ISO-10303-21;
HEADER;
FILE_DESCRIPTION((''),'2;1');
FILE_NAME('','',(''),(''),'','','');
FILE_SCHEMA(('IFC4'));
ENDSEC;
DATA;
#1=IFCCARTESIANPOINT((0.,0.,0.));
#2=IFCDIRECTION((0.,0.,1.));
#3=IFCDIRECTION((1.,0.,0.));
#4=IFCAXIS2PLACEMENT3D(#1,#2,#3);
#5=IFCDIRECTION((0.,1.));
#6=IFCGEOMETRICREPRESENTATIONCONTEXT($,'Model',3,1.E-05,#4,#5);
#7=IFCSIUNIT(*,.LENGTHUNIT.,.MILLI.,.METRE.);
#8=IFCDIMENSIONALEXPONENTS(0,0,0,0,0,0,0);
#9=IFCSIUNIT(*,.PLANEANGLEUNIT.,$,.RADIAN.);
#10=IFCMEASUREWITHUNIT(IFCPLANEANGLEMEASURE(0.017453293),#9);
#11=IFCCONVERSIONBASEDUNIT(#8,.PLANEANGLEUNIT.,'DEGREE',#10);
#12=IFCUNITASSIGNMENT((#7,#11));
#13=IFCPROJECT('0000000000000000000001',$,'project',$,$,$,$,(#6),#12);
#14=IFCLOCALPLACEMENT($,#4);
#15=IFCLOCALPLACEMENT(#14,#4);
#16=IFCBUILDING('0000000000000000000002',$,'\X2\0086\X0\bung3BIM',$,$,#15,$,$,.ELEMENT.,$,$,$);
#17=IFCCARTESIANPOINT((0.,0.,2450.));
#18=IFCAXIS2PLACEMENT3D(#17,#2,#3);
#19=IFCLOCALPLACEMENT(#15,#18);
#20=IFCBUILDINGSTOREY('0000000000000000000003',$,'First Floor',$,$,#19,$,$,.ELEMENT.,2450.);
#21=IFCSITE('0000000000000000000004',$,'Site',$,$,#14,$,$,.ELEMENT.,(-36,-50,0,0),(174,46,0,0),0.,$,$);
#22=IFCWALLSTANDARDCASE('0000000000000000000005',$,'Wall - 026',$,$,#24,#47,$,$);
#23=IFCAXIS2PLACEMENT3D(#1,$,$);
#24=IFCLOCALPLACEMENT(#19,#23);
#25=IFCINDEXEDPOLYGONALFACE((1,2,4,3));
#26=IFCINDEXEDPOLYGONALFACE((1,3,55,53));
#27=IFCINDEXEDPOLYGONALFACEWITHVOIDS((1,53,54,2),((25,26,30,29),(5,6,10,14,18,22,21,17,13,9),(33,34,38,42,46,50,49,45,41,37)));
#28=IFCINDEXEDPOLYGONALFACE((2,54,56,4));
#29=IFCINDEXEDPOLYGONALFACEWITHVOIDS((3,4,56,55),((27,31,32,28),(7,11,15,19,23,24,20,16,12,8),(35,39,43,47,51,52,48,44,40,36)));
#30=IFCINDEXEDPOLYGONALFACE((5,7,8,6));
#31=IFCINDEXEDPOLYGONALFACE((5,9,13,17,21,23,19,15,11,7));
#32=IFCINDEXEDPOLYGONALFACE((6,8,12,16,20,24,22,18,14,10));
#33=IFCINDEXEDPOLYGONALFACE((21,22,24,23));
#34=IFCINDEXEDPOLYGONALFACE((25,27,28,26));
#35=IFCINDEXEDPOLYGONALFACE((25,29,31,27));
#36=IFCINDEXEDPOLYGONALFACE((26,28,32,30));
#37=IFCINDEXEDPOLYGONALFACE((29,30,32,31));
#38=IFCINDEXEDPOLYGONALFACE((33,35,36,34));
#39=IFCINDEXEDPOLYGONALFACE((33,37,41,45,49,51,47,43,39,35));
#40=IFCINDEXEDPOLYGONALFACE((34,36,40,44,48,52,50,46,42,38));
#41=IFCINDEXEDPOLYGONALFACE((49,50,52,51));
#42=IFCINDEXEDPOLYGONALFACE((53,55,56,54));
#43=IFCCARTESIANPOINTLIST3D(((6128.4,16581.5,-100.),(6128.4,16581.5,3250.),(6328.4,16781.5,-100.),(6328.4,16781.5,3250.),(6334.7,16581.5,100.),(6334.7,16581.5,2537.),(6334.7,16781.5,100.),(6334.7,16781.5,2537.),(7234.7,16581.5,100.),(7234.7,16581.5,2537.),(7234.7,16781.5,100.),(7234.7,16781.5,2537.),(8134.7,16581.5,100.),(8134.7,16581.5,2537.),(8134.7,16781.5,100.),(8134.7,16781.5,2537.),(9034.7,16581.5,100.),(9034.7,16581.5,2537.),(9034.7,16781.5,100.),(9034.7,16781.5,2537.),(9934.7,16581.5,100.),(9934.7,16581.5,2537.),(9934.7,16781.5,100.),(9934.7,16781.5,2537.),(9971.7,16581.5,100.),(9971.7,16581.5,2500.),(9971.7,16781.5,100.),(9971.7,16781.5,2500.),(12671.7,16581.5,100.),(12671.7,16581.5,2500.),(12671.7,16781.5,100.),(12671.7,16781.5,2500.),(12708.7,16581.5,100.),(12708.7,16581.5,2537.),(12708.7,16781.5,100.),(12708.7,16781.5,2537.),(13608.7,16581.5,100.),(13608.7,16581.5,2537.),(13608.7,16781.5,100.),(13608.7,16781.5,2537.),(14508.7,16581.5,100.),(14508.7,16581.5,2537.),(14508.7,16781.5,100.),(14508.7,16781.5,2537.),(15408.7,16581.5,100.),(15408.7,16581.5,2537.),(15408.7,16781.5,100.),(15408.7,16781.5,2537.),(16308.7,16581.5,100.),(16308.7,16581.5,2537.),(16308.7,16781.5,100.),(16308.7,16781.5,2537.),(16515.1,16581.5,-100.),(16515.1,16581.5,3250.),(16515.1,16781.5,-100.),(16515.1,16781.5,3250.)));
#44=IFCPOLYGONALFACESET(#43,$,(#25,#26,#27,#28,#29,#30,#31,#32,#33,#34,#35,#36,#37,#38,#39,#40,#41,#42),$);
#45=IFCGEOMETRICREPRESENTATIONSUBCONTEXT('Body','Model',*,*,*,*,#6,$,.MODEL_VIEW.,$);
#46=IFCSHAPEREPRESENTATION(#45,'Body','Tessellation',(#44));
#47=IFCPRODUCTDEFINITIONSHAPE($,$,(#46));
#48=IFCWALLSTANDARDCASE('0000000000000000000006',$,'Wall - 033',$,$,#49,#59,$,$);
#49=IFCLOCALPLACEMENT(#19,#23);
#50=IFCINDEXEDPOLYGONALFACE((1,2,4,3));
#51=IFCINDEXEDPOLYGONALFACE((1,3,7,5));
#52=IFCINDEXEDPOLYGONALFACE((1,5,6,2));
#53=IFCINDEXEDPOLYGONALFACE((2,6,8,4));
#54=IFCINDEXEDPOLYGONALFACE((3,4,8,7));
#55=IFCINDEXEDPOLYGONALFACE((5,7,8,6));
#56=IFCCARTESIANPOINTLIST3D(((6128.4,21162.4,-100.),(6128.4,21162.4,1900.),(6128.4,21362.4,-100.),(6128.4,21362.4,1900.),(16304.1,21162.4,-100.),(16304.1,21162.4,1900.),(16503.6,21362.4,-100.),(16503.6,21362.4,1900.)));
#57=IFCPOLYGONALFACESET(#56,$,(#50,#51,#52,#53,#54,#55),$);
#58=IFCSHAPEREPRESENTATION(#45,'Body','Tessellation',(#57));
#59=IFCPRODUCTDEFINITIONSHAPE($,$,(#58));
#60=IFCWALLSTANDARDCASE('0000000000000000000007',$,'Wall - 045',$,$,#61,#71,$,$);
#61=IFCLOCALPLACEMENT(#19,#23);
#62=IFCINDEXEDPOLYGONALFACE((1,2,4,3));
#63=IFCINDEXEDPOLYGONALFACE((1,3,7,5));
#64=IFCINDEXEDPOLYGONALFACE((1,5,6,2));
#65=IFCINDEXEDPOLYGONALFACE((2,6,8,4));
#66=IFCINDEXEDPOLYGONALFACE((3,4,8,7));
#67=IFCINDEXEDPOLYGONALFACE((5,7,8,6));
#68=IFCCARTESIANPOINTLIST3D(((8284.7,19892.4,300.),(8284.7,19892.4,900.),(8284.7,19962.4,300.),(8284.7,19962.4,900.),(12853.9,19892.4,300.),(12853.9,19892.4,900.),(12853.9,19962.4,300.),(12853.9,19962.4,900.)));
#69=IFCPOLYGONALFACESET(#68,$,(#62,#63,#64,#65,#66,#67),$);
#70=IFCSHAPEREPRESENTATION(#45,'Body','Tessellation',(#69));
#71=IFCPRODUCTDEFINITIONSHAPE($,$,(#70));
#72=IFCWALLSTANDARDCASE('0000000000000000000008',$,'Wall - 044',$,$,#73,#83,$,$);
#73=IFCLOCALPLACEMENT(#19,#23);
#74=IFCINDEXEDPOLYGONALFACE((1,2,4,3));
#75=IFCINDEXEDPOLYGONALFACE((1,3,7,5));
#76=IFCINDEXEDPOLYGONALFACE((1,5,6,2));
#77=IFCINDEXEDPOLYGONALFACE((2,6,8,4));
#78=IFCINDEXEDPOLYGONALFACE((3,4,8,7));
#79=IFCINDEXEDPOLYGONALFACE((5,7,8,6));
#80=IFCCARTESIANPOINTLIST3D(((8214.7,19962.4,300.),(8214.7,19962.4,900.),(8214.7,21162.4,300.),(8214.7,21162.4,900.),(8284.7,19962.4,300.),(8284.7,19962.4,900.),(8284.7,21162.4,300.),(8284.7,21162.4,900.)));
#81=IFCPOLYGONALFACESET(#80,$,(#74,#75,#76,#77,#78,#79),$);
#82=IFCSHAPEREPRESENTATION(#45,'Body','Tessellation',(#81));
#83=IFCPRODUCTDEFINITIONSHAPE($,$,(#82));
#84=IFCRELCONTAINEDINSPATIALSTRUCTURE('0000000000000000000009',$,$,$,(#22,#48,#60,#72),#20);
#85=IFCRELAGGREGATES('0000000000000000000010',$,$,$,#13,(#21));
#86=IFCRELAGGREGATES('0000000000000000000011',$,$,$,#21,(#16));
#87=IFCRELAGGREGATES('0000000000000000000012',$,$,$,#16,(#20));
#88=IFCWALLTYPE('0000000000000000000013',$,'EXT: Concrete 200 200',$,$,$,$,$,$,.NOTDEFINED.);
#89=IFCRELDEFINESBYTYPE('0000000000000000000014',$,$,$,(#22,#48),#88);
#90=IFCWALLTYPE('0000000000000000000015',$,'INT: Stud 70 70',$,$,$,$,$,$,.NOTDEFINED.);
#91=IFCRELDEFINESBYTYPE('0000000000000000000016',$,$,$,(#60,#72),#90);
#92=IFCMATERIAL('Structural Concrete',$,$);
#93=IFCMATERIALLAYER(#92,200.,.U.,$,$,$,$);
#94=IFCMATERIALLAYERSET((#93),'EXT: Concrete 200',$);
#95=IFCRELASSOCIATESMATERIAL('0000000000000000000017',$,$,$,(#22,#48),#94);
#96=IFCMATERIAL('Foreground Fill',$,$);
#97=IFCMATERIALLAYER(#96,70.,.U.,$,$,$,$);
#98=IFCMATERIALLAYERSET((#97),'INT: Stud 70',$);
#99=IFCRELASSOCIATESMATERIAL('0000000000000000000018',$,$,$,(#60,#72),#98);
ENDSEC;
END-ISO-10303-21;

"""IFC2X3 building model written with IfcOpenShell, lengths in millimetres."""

from ifc_helpers import new_model, entity, si_unit, converted_unit, direction, frame, origin_with_axes, origin_2d_with_axis, place, context, subcontext, project, spatial, polyline, rectangle, outline, extrude, material, layer, layer_set, layer_usage, type_object, element, save


model = new_model("IFC2X3")

# Units and contexts
model_context = context("Model", 3, precision=1e-05, world=origin_with_axes(), true_north=direction((0.0, 1.0)))
body_context = subcontext(model_context, "Body", "Model", "MODEL_VIEW")
ifc_project = project(units=[si_unit("LENGTHUNIT", "METRE", prefix="MILLI"), converted_unit("PLANEANGLEUNIT", "DEGREE", entity("IfcPlaneAngleMeasure", 0.017453293), si_unit("PLANEANGLEUNIT", "RADIAN"), dimensions=[0, 0, 0, 0, 0, 0, 0])], contexts=[model_context])

# Site, building, storey
site_placement = place(None, origin_with_axes())
site = spatial("IfcSite", under=ifc_project, at=site_placement, Name="Site", CompositionType="ELEMENT", RefLatitude=(-36, -50, 0, 0), RefLongitude=(174, 46, 0, 0), RefElevation=0.0)
building_placement = place(site_placement, origin_with_axes())
building = spatial("IfcBuilding", under=site, at=building_placement, Name="\u0086bung3BIM", CompositionType="ELEMENT")
storey_placement = place(building_placement, frame((0.0, 0.0, 2450.0), z_axis=(0.0, 0.0, 1.0), x_axis=(1.0, 0.0, 0.0)))
storey = spatial("IfcBuildingStorey", under=building, at=storey_placement, Name="First Floor", CompositionType="ELEMENT", Elevation=2450.0)

# Shared definitions
ifc_material_1 = material(Name="Foreground Fill")

# Wall, openings
ifc_material_2 = material(Name="Structural Concrete")
ifc_layer_1 = layer(ifc_material_2, 200.0, ventilated="UNKNOWN")
ifc_layer_set_1 = layer_set([ifc_layer_1], Name="EXT: Concrete 200")
ifc_layer_usage_1 = layer_usage(ifc_layer_set_1, "AXIS2", "POSITIVE", 0.0)
wall_type_1 = type_object("IfcWallType", Name="EXT: Concrete 200 200", PredefinedType="NOTDEFINED")
wall_1_placement = place(storey_placement, frame((16515.1, 16781.5, -100.0), z_axis=(0.0, 0.0, 1.0), x_axis=(-1.0, 0.0, 0.0)))
wall_1 = element("IfcWallStandardCase", 1, at=wall_1_placement, inside=storey, type_object=wall_type_1, material=ifc_layer_usage_1, Name="Wall - 026", context=body_context, shape_type="SweptSolid", body=[
    extrude(outline(polyline([(0.0, 0.0), (10186.8, 0.0), (10386.8, 200.0), (0.0, 200.0), (0.0, 0.0)])), origin_with_axes(), (0.0, 0.0, 1.0), 3350.0),
])
opening_1_placement = place(wall_1_placement, frame((7930.4, 0.0, 200.0), z_axis=(0.0, 0.0, 1.0), x_axis=(1.0, 0.0, 0.0)))
element("IfcOpeningElement", 2, at=opening_1_placement, cuts=wall_1, context=body_context, shape_type="SweptSolid", body=[
    extrude(rectangle(XDim=900.0, YDim=2437.0, at=origin_2d_with_axis()), frame((0.0, -200.0, 1218.5), z_axis=(0.0, 1.0, 0.0), x_axis=(1.0, 0.0, 0.0)), (0.0, 0.0, 1.0), 600.0),
])
opening_2_placement = place(wall_1_placement, frame((8830.4, 0.0, 200.0), z_axis=(0.0, 0.0, 1.0), x_axis=(1.0, 0.0, 0.0)))
element("IfcOpeningElement", 3, at=opening_2_placement, cuts=wall_1, context=body_context, shape_type="SweptSolid", body=[
    extrude(rectangle(XDim=900.0, YDim=2437.0, at=origin_2d_with_axis()), frame((0.0, -200.0, 1218.5), z_axis=(0.0, 1.0, 0.0), x_axis=(1.0, 0.0, 0.0)), (0.0, 0.0, 1.0), 600.0),
])
opening_3_placement = place(wall_1_placement, frame((3356.4, 0.0, 200.0), z_axis=(0.0, 0.0, 1.0), x_axis=(1.0, 0.0, 0.0)))
element("IfcOpeningElement", 4, at=opening_3_placement, cuts=wall_1, context=body_context, shape_type="SweptSolid", body=[
    extrude(rectangle(XDim=900.0, YDim=2437.0, at=origin_2d_with_axis()), frame((0.0, -200.0, 1218.5), z_axis=(0.0, 1.0, 0.0), x_axis=(1.0, 0.0, 0.0)), (0.0, 0.0, 1.0), 600.0),
])
opening_4_placement = place(wall_1_placement, frame((5193.4, 0.0, 200.0), z_axis=(0.0, 0.0, 1.0), x_axis=(1.0, 0.0, 0.0)))
element("IfcOpeningElement", 5, at=opening_4_placement, cuts=wall_1, context=body_context, shape_type="SweptSolid", body=[
    extrude(rectangle(XDim=2700.0, YDim=2400.0, at=origin_2d_with_axis()), frame((0.0, -200.0, 1200.0), z_axis=(0.0, 1.0, 0.0), x_axis=(1.0, 0.0, 0.0)), (0.0, 0.0, 1.0), 600.0),
    extrude(rectangle(XDim=2774.0, YDim=2437.0, at=origin_2d_with_axis()), frame((0.0, -200.0, 1218.5), z_axis=(0.0, 1.0, 0.0), x_axis=(1.0, 0.0, 0.0)), (0.0, 0.0, 1.0), 200.0),
    extrude(rectangle(XDim=2774.0, YDim=2437.0, at=origin_2d_with_axis()), frame((0.0, 400.0, 1218.5), z_axis=(0.0, -1.0, 0.0), x_axis=(1.0, 0.0, 0.0)), (0.0, 0.0, 1.0), 200.0),
])
opening_5_placement = place(wall_1_placement, frame((2456.4, 0.0, 200.0), z_axis=(0.0, 0.0, 1.0), x_axis=(1.0, 0.0, 0.0)))
element("IfcOpeningElement", 6, at=opening_5_placement, cuts=wall_1, context=body_context, shape_type="SweptSolid", body=[
    extrude(rectangle(XDim=900.0, YDim=2437.0, at=origin_2d_with_axis()), frame((0.0, -200.0, 1218.5), z_axis=(0.0, 1.0, 0.0), x_axis=(1.0, 0.0, 0.0)), (0.0, 0.0, 1.0), 600.0),
])
opening_6_placement = place(wall_1_placement, frame((7030.4, 0.0, 200.0), z_axis=(0.0, 0.0, 1.0), x_axis=(1.0, 0.0, 0.0)))
element("IfcOpeningElement", 7, at=opening_6_placement, cuts=wall_1, context=body_context, shape_type="SweptSolid", body=[
    extrude(rectangle(XDim=900.0, YDim=2437.0, at=origin_2d_with_axis()), frame((0.0, -200.0, 1218.5), z_axis=(0.0, 1.0, 0.0), x_axis=(1.0, 0.0, 0.0)), (0.0, 0.0, 1.0), 600.0),
])
opening_7_placement = place(wall_1_placement, frame((9730.4, 0.0, 200.0), z_axis=(0.0, 0.0, 1.0), x_axis=(1.0, 0.0, 0.0)))
element("IfcOpeningElement", 8, at=opening_7_placement, cuts=wall_1, context=body_context, shape_type="SweptSolid", body=[
    extrude(rectangle(XDim=900.0, YDim=2437.0, at=origin_2d_with_axis()), frame((0.0, -200.0, 1218.5), z_axis=(0.0, 1.0, 0.0), x_axis=(1.0, 0.0, 0.0)), (0.0, 0.0, 1.0), 600.0),
])
opening_8_placement = place(wall_1_placement, frame((1556.4, 0.0, 200.0), z_axis=(0.0, 0.0, 1.0), x_axis=(1.0, 0.0, 0.0)))
element("IfcOpeningElement", 9, at=opening_8_placement, cuts=wall_1, context=body_context, shape_type="SweptSolid", body=[
    extrude(rectangle(XDim=900.0, YDim=2437.0, at=origin_2d_with_axis()), frame((0.0, -200.0, 1218.5), z_axis=(0.0, 1.0, 0.0), x_axis=(1.0, 0.0, 0.0)), (0.0, 0.0, 1.0), 600.0),
])
opening_9_placement = place(wall_1_placement, frame((656.4, 0.0, 200.0), z_axis=(0.0, 0.0, 1.0), x_axis=(1.0, 0.0, 0.0)))
element("IfcOpeningElement", 10, at=opening_9_placement, cuts=wall_1, context=body_context, shape_type="SweptSolid", body=[
    extrude(rectangle(XDim=900.0, YDim=2437.0, at=origin_2d_with_axis()), frame((0.0, -200.0, 1218.5), z_axis=(0.0, 1.0, 0.0), x_axis=(1.0, 0.0, 0.0)), (0.0, 0.0, 1.0), 600.0),
])

# Walls
ifc_layer_usage_2 = layer_usage(ifc_layer_set_1, "AXIS2", "POSITIVE", 0.0)
wall_2_placement = place(storey_placement, frame((6128.4, 21162.4, -100.0), z_axis=(0.0, 0.0, 1.0), x_axis=(1.0, 0.0, 0.0)))
element("IfcWallStandardCase", 11, at=wall_2_placement, inside=storey, type_object=wall_type_1, material=ifc_layer_usage_2, Name="Wall - 033", context=body_context, shape_type="SweptSolid", body=[
    extrude(outline(polyline([(0.0, 0.0), (10175.8, 0.0), (10375.3, 200.0), (0.0, 200.0), (0.0, 0.0)])), origin_with_axes(), (0.0, 0.0, 1.0), 2000.0),
])
ifc_layer_2 = layer(ifc_material_1, 70.0, ventilated="UNKNOWN")
ifc_layer_set_2 = layer_set([ifc_layer_2], Name="INT: Stud 70")
ifc_layer_usage_3 = layer_usage(ifc_layer_set_2, "AXIS2", "POSITIVE", 0.0)
wall_type_2 = type_object("IfcWallType", Name="INT: Stud 70 70", PredefinedType="NOTDEFINED")
wall_3_placement = place(storey_placement, frame((12853.9, 19962.4, 300.0), z_axis=(0.0, 0.0, 1.0), x_axis=(-1.0, 0.0, 0.0)))
element("IfcWallStandardCase", 12, at=wall_3_placement, inside=storey, type_object=wall_type_2, material=ifc_layer_usage_3, Name="Wall - 045", context=body_context, shape_type="SweptSolid", body=[
    extrude(outline(polyline([(0.0, 0.0), (4569.2, 0.0), (4569.2, 70.0), (0.0, 70.0), (0.0, 0.0)])), origin_with_axes(), (0.0, 0.0, 1.0), 600.0),
])
ifc_layer_usage_4 = layer_usage(ifc_layer_set_2, "AXIS2", "POSITIVE", 0.0)
wall_4_placement = place(storey_placement, frame((8284.7, 19962.4, 300.0), z_axis=(0.0, 0.0, 1.0), x_axis=(0.0, 1.0, 0.0)))
element("IfcWallStandardCase", 13, at=wall_4_placement, inside=storey, type_object=wall_type_2, material=ifc_layer_usage_4, Name="Wall - 044", context=body_context, shape_type="SweptSolid", body=[
    extrude(outline(polyline([(0.0, 0.0), (1200.0, 0.0), (1200.0, 70.0), (0.0, 70.0), (0.0, 0.0)])), origin_with_axes(), (0.0, 0.0, 1.0), 600.0),
])

save(model, "model.ifc")
